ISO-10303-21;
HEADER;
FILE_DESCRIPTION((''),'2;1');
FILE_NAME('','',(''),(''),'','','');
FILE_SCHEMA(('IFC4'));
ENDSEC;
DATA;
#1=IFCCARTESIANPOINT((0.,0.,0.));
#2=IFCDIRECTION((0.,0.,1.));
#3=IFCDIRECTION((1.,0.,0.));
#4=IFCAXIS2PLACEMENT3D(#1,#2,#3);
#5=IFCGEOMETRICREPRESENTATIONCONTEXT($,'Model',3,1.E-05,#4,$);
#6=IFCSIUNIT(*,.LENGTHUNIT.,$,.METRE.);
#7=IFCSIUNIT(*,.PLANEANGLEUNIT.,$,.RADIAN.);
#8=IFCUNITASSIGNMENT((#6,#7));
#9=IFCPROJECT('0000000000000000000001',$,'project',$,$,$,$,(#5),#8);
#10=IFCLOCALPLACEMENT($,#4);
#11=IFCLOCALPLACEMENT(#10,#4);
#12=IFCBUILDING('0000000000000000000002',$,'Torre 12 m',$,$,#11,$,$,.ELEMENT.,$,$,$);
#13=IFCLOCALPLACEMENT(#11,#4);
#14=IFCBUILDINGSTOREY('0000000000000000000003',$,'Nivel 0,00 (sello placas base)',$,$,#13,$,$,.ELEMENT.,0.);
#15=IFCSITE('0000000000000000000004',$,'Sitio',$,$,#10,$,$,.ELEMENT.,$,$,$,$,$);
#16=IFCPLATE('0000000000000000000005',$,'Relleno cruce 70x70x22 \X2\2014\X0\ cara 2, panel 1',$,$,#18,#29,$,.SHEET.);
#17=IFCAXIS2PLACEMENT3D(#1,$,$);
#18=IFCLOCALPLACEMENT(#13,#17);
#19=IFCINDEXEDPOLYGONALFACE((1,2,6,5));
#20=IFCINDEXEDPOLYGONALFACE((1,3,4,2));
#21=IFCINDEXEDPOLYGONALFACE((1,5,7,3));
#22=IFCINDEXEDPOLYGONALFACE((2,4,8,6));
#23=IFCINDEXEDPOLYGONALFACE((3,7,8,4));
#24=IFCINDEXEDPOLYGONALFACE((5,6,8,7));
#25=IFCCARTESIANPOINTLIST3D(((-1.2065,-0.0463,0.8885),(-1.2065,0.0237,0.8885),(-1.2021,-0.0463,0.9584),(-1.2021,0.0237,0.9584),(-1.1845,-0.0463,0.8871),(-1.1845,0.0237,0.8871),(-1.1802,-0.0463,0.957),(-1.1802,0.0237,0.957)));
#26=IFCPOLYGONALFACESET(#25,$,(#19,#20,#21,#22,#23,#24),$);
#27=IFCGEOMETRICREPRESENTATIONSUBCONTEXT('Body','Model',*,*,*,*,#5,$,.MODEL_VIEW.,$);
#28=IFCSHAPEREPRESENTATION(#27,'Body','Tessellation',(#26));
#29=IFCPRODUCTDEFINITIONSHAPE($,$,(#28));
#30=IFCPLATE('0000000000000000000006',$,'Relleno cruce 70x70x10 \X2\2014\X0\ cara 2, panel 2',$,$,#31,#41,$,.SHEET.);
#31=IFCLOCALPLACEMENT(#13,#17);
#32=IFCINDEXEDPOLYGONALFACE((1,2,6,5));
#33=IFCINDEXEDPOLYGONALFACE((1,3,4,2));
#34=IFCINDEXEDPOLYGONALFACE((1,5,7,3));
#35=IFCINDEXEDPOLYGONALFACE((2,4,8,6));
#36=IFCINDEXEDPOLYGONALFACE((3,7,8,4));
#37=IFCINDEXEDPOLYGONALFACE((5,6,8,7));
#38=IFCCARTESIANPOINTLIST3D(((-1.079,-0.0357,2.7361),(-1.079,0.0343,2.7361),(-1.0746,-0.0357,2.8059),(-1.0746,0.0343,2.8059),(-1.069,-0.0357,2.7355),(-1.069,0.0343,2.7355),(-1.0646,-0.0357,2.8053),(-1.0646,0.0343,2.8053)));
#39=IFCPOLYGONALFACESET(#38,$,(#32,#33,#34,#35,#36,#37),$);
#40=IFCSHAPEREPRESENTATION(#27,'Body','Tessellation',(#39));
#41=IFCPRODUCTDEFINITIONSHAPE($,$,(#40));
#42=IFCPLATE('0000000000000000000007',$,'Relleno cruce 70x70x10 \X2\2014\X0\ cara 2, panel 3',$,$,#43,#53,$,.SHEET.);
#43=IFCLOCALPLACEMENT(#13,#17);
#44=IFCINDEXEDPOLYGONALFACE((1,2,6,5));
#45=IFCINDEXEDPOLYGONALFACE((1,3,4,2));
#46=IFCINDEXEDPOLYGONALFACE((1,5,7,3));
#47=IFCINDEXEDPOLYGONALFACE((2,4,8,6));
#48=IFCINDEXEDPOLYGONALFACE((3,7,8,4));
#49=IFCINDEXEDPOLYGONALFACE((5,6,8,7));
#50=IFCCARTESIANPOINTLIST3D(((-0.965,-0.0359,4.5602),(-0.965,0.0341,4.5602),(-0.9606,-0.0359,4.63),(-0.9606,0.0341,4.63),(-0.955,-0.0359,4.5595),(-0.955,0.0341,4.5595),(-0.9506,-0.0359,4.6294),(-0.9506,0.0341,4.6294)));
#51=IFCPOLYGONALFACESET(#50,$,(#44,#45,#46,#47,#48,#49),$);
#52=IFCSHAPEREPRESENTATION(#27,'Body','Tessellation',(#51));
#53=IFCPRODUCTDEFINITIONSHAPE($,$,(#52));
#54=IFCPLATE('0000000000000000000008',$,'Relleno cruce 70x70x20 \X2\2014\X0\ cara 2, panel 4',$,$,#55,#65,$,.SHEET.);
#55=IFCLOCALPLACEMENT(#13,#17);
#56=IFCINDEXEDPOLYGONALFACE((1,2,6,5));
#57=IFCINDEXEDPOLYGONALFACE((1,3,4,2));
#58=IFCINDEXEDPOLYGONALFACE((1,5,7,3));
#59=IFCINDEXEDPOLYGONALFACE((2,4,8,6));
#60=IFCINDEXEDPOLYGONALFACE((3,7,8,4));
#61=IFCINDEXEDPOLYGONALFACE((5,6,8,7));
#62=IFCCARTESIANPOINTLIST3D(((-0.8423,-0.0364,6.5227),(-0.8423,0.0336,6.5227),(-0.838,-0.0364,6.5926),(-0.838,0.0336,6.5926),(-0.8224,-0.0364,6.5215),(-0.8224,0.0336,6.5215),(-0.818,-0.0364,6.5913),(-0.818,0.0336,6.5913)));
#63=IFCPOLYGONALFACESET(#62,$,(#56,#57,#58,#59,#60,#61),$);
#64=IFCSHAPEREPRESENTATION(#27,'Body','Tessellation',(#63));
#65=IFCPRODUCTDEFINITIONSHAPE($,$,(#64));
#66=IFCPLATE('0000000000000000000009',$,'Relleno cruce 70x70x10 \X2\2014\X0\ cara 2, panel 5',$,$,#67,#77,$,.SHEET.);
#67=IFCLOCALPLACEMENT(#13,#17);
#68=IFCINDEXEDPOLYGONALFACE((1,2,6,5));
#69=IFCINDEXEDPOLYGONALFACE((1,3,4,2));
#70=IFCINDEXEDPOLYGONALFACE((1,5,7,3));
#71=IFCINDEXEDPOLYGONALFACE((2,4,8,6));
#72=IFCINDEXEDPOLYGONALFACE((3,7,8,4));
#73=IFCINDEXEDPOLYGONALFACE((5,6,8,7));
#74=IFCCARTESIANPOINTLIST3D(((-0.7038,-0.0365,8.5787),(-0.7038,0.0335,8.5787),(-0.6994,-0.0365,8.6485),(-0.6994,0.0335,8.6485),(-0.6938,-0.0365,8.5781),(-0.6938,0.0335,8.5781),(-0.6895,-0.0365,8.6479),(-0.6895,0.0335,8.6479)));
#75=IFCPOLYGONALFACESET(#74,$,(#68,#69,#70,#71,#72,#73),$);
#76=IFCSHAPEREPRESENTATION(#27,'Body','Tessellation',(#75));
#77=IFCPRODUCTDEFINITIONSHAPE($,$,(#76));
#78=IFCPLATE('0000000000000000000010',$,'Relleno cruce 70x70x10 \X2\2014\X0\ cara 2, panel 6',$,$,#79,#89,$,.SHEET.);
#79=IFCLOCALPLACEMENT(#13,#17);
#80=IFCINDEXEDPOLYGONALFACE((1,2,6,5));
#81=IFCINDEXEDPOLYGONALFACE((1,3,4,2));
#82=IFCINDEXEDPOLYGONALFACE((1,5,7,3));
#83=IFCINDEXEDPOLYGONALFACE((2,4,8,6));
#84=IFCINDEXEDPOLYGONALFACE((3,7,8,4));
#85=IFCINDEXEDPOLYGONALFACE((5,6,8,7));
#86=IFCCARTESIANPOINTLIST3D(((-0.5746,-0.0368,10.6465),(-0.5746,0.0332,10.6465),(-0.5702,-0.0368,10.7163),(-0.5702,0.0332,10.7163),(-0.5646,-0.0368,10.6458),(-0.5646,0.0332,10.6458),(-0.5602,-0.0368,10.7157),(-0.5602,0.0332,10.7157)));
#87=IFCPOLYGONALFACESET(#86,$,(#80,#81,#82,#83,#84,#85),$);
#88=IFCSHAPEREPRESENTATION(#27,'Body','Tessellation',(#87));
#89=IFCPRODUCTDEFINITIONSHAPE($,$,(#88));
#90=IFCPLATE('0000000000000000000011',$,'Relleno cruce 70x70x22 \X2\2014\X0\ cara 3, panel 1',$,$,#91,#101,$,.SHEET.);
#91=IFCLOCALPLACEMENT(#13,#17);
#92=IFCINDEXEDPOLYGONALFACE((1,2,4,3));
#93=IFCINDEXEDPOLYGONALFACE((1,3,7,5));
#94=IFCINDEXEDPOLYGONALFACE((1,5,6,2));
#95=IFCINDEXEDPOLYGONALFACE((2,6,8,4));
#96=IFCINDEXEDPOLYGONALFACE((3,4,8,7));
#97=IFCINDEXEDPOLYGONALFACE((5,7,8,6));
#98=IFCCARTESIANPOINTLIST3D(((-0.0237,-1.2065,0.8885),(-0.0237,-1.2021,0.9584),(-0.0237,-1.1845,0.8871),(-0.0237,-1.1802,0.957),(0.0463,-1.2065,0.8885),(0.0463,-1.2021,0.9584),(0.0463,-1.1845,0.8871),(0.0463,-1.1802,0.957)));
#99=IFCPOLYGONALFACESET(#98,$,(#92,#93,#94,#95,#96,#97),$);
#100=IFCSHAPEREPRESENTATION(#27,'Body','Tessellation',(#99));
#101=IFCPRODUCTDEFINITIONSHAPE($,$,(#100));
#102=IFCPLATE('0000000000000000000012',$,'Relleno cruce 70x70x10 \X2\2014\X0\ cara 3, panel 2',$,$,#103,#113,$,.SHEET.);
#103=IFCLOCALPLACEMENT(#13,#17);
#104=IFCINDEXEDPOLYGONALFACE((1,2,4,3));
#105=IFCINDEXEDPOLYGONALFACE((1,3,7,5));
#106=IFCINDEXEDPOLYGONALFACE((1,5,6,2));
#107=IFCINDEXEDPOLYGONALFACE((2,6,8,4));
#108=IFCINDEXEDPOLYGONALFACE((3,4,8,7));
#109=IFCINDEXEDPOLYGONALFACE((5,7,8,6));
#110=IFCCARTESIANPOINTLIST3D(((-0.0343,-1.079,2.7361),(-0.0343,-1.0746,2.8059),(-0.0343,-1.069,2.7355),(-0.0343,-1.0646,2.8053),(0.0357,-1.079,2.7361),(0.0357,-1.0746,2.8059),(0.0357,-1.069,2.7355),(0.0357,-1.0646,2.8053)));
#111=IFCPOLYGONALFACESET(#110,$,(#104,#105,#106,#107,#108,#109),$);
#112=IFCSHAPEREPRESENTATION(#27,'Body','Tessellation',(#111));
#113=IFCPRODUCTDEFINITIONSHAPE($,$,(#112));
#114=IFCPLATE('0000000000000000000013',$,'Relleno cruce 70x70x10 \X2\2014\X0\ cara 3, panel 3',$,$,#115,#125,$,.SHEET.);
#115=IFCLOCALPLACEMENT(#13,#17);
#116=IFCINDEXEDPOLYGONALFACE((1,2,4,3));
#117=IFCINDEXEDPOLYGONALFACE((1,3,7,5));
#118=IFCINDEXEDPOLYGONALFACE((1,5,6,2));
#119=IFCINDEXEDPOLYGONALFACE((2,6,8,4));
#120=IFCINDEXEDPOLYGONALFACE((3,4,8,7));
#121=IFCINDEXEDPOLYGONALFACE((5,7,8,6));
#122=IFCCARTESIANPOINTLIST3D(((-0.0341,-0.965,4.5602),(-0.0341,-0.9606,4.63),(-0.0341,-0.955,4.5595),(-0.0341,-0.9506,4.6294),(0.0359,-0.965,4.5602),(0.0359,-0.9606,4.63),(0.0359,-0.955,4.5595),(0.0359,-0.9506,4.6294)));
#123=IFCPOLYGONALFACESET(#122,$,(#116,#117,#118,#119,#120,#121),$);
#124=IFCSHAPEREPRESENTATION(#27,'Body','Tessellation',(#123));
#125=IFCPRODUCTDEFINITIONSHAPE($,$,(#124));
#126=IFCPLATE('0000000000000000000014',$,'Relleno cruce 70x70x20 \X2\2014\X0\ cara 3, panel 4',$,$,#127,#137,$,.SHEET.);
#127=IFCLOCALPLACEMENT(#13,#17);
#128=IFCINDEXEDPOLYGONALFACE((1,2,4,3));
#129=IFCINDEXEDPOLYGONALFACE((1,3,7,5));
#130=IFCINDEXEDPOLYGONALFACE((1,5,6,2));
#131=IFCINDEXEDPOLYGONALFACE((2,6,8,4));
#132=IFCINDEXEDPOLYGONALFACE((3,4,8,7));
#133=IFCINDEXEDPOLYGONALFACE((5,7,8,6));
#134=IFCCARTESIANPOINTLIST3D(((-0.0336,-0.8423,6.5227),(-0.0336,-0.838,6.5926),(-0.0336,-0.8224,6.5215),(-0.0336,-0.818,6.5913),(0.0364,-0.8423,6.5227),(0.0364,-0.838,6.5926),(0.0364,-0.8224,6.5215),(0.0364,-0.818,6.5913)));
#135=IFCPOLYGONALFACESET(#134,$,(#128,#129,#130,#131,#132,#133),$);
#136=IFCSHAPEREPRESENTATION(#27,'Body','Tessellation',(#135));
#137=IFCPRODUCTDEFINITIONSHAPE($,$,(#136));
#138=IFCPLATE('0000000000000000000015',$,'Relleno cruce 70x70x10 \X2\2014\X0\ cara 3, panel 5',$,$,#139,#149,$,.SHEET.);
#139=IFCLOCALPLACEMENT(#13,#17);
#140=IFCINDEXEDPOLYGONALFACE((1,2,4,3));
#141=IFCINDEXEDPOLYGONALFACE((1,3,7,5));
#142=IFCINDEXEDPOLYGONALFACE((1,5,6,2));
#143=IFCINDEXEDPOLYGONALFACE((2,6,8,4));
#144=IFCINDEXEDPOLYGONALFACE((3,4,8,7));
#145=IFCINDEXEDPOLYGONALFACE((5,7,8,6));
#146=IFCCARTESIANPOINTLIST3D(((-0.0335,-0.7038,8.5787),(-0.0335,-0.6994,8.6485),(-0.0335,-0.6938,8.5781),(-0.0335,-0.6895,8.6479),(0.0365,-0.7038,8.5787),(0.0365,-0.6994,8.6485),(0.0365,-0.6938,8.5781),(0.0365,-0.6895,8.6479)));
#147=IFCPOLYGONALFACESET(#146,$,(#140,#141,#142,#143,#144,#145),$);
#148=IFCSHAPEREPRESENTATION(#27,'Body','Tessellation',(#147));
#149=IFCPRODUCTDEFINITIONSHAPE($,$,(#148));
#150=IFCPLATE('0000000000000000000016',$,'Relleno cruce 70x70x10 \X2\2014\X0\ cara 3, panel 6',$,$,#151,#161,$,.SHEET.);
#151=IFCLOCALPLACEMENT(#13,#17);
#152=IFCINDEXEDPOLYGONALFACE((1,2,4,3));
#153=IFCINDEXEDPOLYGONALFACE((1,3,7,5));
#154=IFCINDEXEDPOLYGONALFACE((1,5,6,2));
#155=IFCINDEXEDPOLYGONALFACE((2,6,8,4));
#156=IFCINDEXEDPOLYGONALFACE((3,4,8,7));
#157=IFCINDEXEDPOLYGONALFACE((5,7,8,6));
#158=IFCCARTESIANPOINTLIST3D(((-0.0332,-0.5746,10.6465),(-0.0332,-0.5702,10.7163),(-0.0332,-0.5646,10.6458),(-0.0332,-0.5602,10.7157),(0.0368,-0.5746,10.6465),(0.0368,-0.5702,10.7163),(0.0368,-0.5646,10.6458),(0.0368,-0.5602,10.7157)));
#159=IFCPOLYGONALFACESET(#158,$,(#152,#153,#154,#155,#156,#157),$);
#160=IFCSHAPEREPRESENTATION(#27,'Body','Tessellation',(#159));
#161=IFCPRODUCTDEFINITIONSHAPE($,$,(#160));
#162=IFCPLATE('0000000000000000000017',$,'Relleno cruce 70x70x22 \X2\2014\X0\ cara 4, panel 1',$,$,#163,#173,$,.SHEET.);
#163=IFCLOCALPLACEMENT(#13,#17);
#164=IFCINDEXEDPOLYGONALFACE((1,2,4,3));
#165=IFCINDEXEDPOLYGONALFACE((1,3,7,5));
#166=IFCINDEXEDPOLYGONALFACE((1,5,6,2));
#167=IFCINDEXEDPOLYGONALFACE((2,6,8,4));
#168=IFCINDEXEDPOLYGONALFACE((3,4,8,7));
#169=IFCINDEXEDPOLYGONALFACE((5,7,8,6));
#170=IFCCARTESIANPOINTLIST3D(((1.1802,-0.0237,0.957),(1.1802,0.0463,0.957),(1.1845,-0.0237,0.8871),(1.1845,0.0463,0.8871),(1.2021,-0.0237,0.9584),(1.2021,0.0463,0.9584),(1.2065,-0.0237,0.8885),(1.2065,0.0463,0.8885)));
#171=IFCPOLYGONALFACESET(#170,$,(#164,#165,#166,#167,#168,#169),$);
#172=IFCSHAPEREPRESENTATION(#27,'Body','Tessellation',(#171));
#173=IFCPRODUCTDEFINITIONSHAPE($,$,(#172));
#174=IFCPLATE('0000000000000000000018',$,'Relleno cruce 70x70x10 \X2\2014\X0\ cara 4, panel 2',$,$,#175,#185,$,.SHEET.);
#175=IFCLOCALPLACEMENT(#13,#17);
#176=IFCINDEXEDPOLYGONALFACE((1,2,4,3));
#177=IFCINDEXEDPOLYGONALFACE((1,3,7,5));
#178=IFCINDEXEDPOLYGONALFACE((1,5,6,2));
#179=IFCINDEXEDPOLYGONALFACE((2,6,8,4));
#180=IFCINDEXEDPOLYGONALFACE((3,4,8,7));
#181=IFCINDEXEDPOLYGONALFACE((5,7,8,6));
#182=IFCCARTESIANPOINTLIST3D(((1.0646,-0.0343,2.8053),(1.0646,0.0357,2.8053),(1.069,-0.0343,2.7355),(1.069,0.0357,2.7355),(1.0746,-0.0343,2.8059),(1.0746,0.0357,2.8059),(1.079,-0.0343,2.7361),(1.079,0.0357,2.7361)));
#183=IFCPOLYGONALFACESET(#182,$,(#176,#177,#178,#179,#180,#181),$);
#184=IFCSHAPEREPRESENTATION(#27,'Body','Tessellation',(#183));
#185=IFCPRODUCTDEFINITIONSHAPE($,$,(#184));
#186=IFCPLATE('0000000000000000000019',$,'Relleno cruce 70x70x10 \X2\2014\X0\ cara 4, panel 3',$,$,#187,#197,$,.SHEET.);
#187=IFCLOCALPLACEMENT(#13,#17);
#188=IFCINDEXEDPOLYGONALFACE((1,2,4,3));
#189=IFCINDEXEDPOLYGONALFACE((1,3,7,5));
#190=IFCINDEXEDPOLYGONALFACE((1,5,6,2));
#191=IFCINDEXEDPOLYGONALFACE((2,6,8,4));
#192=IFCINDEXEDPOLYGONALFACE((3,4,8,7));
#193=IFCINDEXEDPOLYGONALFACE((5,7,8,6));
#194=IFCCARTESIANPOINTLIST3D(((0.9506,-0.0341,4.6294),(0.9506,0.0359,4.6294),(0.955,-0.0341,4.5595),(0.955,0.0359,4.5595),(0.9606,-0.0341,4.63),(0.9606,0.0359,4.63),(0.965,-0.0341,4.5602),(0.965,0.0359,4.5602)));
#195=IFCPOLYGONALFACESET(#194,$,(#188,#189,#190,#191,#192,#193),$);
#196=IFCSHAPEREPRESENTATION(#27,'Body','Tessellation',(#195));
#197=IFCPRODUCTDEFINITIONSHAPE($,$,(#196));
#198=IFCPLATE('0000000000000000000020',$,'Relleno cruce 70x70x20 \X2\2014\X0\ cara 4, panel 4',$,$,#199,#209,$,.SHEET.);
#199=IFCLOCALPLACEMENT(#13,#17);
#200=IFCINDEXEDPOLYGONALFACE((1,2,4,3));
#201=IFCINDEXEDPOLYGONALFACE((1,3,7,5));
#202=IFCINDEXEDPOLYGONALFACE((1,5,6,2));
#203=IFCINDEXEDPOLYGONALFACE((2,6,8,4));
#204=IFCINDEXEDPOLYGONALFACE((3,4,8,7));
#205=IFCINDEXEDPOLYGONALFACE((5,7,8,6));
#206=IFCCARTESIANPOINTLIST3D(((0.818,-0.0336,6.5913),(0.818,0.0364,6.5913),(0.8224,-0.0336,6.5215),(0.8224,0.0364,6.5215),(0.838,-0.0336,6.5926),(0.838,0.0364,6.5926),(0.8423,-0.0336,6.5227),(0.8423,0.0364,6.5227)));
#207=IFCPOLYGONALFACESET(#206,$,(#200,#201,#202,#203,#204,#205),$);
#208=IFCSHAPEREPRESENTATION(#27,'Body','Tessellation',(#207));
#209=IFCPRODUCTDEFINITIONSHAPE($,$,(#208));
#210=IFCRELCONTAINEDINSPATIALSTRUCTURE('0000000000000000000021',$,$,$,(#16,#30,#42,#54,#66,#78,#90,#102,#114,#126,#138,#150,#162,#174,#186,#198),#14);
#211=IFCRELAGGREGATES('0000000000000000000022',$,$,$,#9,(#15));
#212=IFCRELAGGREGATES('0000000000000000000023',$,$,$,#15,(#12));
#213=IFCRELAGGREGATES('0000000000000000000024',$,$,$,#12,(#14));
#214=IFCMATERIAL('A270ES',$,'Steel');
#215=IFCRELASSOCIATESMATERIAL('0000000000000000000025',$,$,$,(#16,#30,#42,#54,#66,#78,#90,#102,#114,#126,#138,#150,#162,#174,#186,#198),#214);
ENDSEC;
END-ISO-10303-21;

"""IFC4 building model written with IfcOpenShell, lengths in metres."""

from ifc_helpers import new_model, si_unit, frame, origin_with_axes, place, context, subcontext, project, spatial, polyline, outline, extrude, material, element, save


model = new_model("IFC4")

# Units and contexts
model_context = context("Model", 3, precision=1e-05, world=origin_with_axes())
body_context = subcontext(model_context, "Body", "Model", "MODEL_VIEW")
ifc_project = project(units=[si_unit("LENGTHUNIT", "METRE"), si_unit("PLANEANGLEUNIT", "RADIAN")], contexts=[model_context])

# Site, building, storey
site_placement = place(None, origin_with_axes())
site = spatial("IfcSite", under=ifc_project, at=site_placement, Name="Sitio", CompositionType="ELEMENT")
building_placement = place(site_placement, origin_with_axes())
building = spatial("IfcBuilding", under=site, at=building_placement, Name="Torre 12 m", CompositionType="ELEMENT")
storey_placement = place(building_placement, origin_with_axes())
storey = spatial("IfcBuildingStorey", under=building, at=storey_placement, Name="Nivel 0,00 (sello placas base)", CompositionType="ELEMENT", Elevation=0.0)

# Plates
ifc_material_1 = material(Name="A270ES", Category="Steel")
placement = place(storey_placement, origin_with_axes())
element("IfcPlate", 1, at=placement, inside=storey, material=ifc_material_1, Name="Relleno cruce 70x70x22 — cara 2, panel 1", PredefinedType="SHEET", context=body_context, shape_type="SweptSolid", body=[
    extrude(outline(polyline([(-0.035, -0.035), (0.035, -0.035), (0.035, 0.035), (-0.035, 0.035), (-0.035, -0.035)])), frame((-1.2043, -0.0113, 0.9234), z_axis=(0.998053, 0.0, -0.062378), x_axis=(0.0, -1.0, 0.0)), (0.0, 0.0, 1.0), 0.022),
])
element("IfcPlate", 2, at=placement, inside=storey, material=ifc_material_1, Name="Relleno cruce 70x70x10 — cara 2, panel 2", PredefinedType="SHEET", context=body_context, shape_type="SweptSolid", body=[
    extrude(outline(polyline([(-0.035, -0.035), (0.035, -0.035), (0.035, 0.035), (-0.035, 0.035), (-0.035, -0.035)])), frame((-1.0768, -0.0007, 2.771), z_axis=(0.998053, 0.0, -0.062378), x_axis=(0.0, -1.0, 0.0)), (0.0, 0.0, 1.0), 0.01),
])
element("IfcPlate", 3, at=placement, inside=storey, material=ifc_material_1, Name="Relleno cruce 70x70x10 — cara 2, panel 3", PredefinedType="SHEET", context=body_context, shape_type="SweptSolid", body=[
    extrude(outline(polyline([(-0.035, -0.035), (0.035, -0.035), (0.035, 0.035), (-0.035, 0.035), (-0.035, -0.035)])), frame((-0.9628, -0.0009, 4.5951), z_axis=(0.998053, 0.0, -0.062378), x_axis=(0.0, -1.0, 0.0)), (0.0, 0.0, 1.0), 0.01),
])
element("IfcPlate", 4, at=placement, inside=storey, material=ifc_material_1, Name="Relleno cruce 70x70x20 — cara 2, panel 4", PredefinedType="SHEET", context=body_context, shape_type="SweptSolid", body=[
    extrude(outline(polyline([(-0.035, -0.035), (0.035, -0.035), (0.035, 0.035), (-0.035, 0.035), (-0.035, -0.035)])), frame((-0.8401, -0.0014, 6.5577), z_axis=(0.998053, 0.0, -0.062378), x_axis=(0.0, -1.0, 0.0)), (0.0, 0.0, 1.0), 0.02),
])
element("IfcPlate", 5, at=placement, inside=storey, material=ifc_material_1, Name="Relleno cruce 70x70x10 — cara 2, panel 5", PredefinedType="SHEET", context=body_context, shape_type="SweptSolid", body=[
    extrude(outline(polyline([(-0.035, -0.035), (0.035, -0.035), (0.035, 0.035), (-0.035, 0.035), (-0.035, -0.035)])), frame((-0.7016, -0.0015, 8.6136), z_axis=(0.998053, 0.0, -0.062378), x_axis=(0.0, -1.0, 0.0)), (0.0, 0.0, 1.0), 0.01),
])
element("IfcPlate", 6, at=placement, inside=storey, material=ifc_material_1, Name="Relleno cruce 70x70x10 — cara 2, panel 6", PredefinedType="SHEET", context=body_context, shape_type="SweptSolid", body=[
    extrude(outline(polyline([(-0.035, -0.035), (0.035, -0.035), (0.035, 0.035), (-0.035, 0.035), (-0.035, -0.035)])), frame((-0.5724, -0.0018, 10.6814), z_axis=(0.998053, 0.0, -0.062378), x_axis=(0.0, -1.0, 0.0)), (0.0, 0.0, 1.0), 0.01),
])
element("IfcPlate", 7, at=placement, inside=storey, material=ifc_material_1, Name="Relleno cruce 70x70x22 — cara 3, panel 1", PredefinedType="SHEET", context=body_context, shape_type="SweptSolid", body=[
    extrude(outline(polyline([(-0.035, -0.035), (0.035, -0.035), (0.035, 0.035), (-0.035, 0.035), (-0.035, -0.035)])), frame((0.0113, -1.2043, 0.9234), z_axis=(0.0, 0.998053, -0.062378), x_axis=(1.0, 0.0, 0.0)), (0.0, 0.0, 1.0), 0.022),
])
element("IfcPlate", 8, at=placement, inside=storey, material=ifc_material_1, Name="Relleno cruce 70x70x10 — cara 3, panel 2", PredefinedType="SHEET", context=body_context, shape_type="SweptSolid", body=[
    extrude(outline(polyline([(-0.035, -0.035), (0.035, -0.035), (0.035, 0.035), (-0.035, 0.035), (-0.035, -0.035)])), frame((0.0007, -1.0768, 2.771), z_axis=(0.0, 0.998053, -0.062378), x_axis=(1.0, 0.0, 0.0)), (0.0, 0.0, 1.0), 0.01),
])
element("IfcPlate", 9, at=placement, inside=storey, material=ifc_material_1, Name="Relleno cruce 70x70x10 — cara 3, panel 3", PredefinedType="SHEET", context=body_context, shape_type="SweptSolid", body=[
    extrude(outline(polyline([(-0.035, -0.035), (0.035, -0.035), (0.035, 0.035), (-0.035, 0.035), (-0.035, -0.035)])), frame((0.0009, -0.9628, 4.5951), z_axis=(0.0, 0.998053, -0.062378), x_axis=(1.0, 0.0, 0.0)), (0.0, 0.0, 1.0), 0.01),
])
element("IfcPlate", 10, at=placement, inside=storey, material=ifc_material_1, Name="Relleno cruce 70x70x20 — cara 3, panel 4", PredefinedType="SHEET", context=body_context, shape_type="SweptSolid", body=[
    extrude(outline(polyline([(-0.035, -0.035), (0.035, -0.035), (0.035, 0.035), (-0.035, 0.035), (-0.035, -0.035)])), frame((0.0014, -0.8401, 6.5577), z_axis=(0.0, 0.998053, -0.062378), x_axis=(1.0, 0.0, 0.0)), (0.0, 0.0, 1.0), 0.02),
])
element("IfcPlate", 11, at=placement, inside=storey, material=ifc_material_1, Name="Relleno cruce 70x70x10 — cara 3, panel 5", PredefinedType="SHEET", context=body_context, shape_type="SweptSolid", body=[
    extrude(outline(polyline([(-0.035, -0.035), (0.035, -0.035), (0.035, 0.035), (-0.035, 0.035), (-0.035, -0.035)])), frame((0.0015, -0.7016, 8.6136), z_axis=(0.0, 0.998053, -0.062378), x_axis=(1.0, 0.0, 0.0)), (0.0, 0.0, 1.0), 0.01),
])
element("IfcPlate", 12, at=placement, inside=storey, material=ifc_material_1, Name="Relleno cruce 70x70x10 — cara 3, panel 6", PredefinedType="SHEET", context=body_context, shape_type="SweptSolid", body=[
    extrude(outline(polyline([(-0.035, -0.035), (0.035, -0.035), (0.035, 0.035), (-0.035, 0.035), (-0.035, -0.035)])), frame((0.0018, -0.5724, 10.6814), z_axis=(0.0, 0.998053, -0.062378), x_axis=(1.0, 0.0, 0.0)), (0.0, 0.0, 1.0), 0.01),
])
element("IfcPlate", 13, at=placement, inside=storey, material=ifc_material_1, Name="Relleno cruce 70x70x22 — cara 4, panel 1", PredefinedType="SHEET", context=body_context, shape_type="SweptSolid", body=[
    extrude(outline(polyline([(-0.035, -0.035), (0.035, -0.035), (0.035, 0.035), (-0.035, 0.035), (-0.035, -0.035)])), frame((1.2043, 0.0113, 0.9234), z_axis=(-0.998053, 0.0, -0.062378), x_axis=(0.0, 1.0, 0.0)), (0.0, 0.0, 1.0), 0.022),
])
element("IfcPlate", 14, at=placement, inside=storey, material=ifc_material_1, Name="Relleno cruce 70x70x10 — cara 4, panel 2", PredefinedType="SHEET", context=body_context, shape_type="SweptSolid", body=[
    extrude(outline(polyline([(-0.035, -0.035), (0.035, -0.035), (0.035, 0.035), (-0.035, 0.035), (-0.035, -0.035)])), frame((1.0768, 0.0007, 2.771), z_axis=(-0.998053, 0.0, -0.062378), x_axis=(0.0, 1.0, 0.0)), (0.0, 0.0, 1.0), 0.01),
])
element("IfcPlate", 15, at=placement, inside=storey, material=ifc_material_1, Name="Relleno cruce 70x70x10 — cara 4, panel 3", PredefinedType="SHEET", context=body_context, shape_type="SweptSolid", body=[
    extrude(outline(polyline([(-0.035, -0.035), (0.035, -0.035), (0.035, 0.035), (-0.035, 0.035), (-0.035, -0.035)])), frame((0.9628, 0.0009, 4.5951), z_axis=(-0.998053, 0.0, -0.062378), x_axis=(0.0, 1.0, 0.0)), (0.0, 0.0, 1.0), 0.01),
])
element("IfcPlate", 16, at=placement, inside=storey, material=ifc_material_1, Name="Relleno cruce 70x70x20 — cara 4, panel 4", PredefinedType="SHEET", context=body_context, shape_type="SweptSolid", body=[
    extrude(outline(polyline([(-0.035, -0.035), (0.035, -0.035), (0.035, 0.035), (-0.035, 0.035), (-0.035, -0.035)])), frame((0.8401, 0.0014, 6.5577), z_axis=(-0.998053, 0.0, -0.062378), x_axis=(0.0, 1.0, 0.0)), (0.0, 0.0, 1.0), 0.02),
])

save(model, "model.ifc")
